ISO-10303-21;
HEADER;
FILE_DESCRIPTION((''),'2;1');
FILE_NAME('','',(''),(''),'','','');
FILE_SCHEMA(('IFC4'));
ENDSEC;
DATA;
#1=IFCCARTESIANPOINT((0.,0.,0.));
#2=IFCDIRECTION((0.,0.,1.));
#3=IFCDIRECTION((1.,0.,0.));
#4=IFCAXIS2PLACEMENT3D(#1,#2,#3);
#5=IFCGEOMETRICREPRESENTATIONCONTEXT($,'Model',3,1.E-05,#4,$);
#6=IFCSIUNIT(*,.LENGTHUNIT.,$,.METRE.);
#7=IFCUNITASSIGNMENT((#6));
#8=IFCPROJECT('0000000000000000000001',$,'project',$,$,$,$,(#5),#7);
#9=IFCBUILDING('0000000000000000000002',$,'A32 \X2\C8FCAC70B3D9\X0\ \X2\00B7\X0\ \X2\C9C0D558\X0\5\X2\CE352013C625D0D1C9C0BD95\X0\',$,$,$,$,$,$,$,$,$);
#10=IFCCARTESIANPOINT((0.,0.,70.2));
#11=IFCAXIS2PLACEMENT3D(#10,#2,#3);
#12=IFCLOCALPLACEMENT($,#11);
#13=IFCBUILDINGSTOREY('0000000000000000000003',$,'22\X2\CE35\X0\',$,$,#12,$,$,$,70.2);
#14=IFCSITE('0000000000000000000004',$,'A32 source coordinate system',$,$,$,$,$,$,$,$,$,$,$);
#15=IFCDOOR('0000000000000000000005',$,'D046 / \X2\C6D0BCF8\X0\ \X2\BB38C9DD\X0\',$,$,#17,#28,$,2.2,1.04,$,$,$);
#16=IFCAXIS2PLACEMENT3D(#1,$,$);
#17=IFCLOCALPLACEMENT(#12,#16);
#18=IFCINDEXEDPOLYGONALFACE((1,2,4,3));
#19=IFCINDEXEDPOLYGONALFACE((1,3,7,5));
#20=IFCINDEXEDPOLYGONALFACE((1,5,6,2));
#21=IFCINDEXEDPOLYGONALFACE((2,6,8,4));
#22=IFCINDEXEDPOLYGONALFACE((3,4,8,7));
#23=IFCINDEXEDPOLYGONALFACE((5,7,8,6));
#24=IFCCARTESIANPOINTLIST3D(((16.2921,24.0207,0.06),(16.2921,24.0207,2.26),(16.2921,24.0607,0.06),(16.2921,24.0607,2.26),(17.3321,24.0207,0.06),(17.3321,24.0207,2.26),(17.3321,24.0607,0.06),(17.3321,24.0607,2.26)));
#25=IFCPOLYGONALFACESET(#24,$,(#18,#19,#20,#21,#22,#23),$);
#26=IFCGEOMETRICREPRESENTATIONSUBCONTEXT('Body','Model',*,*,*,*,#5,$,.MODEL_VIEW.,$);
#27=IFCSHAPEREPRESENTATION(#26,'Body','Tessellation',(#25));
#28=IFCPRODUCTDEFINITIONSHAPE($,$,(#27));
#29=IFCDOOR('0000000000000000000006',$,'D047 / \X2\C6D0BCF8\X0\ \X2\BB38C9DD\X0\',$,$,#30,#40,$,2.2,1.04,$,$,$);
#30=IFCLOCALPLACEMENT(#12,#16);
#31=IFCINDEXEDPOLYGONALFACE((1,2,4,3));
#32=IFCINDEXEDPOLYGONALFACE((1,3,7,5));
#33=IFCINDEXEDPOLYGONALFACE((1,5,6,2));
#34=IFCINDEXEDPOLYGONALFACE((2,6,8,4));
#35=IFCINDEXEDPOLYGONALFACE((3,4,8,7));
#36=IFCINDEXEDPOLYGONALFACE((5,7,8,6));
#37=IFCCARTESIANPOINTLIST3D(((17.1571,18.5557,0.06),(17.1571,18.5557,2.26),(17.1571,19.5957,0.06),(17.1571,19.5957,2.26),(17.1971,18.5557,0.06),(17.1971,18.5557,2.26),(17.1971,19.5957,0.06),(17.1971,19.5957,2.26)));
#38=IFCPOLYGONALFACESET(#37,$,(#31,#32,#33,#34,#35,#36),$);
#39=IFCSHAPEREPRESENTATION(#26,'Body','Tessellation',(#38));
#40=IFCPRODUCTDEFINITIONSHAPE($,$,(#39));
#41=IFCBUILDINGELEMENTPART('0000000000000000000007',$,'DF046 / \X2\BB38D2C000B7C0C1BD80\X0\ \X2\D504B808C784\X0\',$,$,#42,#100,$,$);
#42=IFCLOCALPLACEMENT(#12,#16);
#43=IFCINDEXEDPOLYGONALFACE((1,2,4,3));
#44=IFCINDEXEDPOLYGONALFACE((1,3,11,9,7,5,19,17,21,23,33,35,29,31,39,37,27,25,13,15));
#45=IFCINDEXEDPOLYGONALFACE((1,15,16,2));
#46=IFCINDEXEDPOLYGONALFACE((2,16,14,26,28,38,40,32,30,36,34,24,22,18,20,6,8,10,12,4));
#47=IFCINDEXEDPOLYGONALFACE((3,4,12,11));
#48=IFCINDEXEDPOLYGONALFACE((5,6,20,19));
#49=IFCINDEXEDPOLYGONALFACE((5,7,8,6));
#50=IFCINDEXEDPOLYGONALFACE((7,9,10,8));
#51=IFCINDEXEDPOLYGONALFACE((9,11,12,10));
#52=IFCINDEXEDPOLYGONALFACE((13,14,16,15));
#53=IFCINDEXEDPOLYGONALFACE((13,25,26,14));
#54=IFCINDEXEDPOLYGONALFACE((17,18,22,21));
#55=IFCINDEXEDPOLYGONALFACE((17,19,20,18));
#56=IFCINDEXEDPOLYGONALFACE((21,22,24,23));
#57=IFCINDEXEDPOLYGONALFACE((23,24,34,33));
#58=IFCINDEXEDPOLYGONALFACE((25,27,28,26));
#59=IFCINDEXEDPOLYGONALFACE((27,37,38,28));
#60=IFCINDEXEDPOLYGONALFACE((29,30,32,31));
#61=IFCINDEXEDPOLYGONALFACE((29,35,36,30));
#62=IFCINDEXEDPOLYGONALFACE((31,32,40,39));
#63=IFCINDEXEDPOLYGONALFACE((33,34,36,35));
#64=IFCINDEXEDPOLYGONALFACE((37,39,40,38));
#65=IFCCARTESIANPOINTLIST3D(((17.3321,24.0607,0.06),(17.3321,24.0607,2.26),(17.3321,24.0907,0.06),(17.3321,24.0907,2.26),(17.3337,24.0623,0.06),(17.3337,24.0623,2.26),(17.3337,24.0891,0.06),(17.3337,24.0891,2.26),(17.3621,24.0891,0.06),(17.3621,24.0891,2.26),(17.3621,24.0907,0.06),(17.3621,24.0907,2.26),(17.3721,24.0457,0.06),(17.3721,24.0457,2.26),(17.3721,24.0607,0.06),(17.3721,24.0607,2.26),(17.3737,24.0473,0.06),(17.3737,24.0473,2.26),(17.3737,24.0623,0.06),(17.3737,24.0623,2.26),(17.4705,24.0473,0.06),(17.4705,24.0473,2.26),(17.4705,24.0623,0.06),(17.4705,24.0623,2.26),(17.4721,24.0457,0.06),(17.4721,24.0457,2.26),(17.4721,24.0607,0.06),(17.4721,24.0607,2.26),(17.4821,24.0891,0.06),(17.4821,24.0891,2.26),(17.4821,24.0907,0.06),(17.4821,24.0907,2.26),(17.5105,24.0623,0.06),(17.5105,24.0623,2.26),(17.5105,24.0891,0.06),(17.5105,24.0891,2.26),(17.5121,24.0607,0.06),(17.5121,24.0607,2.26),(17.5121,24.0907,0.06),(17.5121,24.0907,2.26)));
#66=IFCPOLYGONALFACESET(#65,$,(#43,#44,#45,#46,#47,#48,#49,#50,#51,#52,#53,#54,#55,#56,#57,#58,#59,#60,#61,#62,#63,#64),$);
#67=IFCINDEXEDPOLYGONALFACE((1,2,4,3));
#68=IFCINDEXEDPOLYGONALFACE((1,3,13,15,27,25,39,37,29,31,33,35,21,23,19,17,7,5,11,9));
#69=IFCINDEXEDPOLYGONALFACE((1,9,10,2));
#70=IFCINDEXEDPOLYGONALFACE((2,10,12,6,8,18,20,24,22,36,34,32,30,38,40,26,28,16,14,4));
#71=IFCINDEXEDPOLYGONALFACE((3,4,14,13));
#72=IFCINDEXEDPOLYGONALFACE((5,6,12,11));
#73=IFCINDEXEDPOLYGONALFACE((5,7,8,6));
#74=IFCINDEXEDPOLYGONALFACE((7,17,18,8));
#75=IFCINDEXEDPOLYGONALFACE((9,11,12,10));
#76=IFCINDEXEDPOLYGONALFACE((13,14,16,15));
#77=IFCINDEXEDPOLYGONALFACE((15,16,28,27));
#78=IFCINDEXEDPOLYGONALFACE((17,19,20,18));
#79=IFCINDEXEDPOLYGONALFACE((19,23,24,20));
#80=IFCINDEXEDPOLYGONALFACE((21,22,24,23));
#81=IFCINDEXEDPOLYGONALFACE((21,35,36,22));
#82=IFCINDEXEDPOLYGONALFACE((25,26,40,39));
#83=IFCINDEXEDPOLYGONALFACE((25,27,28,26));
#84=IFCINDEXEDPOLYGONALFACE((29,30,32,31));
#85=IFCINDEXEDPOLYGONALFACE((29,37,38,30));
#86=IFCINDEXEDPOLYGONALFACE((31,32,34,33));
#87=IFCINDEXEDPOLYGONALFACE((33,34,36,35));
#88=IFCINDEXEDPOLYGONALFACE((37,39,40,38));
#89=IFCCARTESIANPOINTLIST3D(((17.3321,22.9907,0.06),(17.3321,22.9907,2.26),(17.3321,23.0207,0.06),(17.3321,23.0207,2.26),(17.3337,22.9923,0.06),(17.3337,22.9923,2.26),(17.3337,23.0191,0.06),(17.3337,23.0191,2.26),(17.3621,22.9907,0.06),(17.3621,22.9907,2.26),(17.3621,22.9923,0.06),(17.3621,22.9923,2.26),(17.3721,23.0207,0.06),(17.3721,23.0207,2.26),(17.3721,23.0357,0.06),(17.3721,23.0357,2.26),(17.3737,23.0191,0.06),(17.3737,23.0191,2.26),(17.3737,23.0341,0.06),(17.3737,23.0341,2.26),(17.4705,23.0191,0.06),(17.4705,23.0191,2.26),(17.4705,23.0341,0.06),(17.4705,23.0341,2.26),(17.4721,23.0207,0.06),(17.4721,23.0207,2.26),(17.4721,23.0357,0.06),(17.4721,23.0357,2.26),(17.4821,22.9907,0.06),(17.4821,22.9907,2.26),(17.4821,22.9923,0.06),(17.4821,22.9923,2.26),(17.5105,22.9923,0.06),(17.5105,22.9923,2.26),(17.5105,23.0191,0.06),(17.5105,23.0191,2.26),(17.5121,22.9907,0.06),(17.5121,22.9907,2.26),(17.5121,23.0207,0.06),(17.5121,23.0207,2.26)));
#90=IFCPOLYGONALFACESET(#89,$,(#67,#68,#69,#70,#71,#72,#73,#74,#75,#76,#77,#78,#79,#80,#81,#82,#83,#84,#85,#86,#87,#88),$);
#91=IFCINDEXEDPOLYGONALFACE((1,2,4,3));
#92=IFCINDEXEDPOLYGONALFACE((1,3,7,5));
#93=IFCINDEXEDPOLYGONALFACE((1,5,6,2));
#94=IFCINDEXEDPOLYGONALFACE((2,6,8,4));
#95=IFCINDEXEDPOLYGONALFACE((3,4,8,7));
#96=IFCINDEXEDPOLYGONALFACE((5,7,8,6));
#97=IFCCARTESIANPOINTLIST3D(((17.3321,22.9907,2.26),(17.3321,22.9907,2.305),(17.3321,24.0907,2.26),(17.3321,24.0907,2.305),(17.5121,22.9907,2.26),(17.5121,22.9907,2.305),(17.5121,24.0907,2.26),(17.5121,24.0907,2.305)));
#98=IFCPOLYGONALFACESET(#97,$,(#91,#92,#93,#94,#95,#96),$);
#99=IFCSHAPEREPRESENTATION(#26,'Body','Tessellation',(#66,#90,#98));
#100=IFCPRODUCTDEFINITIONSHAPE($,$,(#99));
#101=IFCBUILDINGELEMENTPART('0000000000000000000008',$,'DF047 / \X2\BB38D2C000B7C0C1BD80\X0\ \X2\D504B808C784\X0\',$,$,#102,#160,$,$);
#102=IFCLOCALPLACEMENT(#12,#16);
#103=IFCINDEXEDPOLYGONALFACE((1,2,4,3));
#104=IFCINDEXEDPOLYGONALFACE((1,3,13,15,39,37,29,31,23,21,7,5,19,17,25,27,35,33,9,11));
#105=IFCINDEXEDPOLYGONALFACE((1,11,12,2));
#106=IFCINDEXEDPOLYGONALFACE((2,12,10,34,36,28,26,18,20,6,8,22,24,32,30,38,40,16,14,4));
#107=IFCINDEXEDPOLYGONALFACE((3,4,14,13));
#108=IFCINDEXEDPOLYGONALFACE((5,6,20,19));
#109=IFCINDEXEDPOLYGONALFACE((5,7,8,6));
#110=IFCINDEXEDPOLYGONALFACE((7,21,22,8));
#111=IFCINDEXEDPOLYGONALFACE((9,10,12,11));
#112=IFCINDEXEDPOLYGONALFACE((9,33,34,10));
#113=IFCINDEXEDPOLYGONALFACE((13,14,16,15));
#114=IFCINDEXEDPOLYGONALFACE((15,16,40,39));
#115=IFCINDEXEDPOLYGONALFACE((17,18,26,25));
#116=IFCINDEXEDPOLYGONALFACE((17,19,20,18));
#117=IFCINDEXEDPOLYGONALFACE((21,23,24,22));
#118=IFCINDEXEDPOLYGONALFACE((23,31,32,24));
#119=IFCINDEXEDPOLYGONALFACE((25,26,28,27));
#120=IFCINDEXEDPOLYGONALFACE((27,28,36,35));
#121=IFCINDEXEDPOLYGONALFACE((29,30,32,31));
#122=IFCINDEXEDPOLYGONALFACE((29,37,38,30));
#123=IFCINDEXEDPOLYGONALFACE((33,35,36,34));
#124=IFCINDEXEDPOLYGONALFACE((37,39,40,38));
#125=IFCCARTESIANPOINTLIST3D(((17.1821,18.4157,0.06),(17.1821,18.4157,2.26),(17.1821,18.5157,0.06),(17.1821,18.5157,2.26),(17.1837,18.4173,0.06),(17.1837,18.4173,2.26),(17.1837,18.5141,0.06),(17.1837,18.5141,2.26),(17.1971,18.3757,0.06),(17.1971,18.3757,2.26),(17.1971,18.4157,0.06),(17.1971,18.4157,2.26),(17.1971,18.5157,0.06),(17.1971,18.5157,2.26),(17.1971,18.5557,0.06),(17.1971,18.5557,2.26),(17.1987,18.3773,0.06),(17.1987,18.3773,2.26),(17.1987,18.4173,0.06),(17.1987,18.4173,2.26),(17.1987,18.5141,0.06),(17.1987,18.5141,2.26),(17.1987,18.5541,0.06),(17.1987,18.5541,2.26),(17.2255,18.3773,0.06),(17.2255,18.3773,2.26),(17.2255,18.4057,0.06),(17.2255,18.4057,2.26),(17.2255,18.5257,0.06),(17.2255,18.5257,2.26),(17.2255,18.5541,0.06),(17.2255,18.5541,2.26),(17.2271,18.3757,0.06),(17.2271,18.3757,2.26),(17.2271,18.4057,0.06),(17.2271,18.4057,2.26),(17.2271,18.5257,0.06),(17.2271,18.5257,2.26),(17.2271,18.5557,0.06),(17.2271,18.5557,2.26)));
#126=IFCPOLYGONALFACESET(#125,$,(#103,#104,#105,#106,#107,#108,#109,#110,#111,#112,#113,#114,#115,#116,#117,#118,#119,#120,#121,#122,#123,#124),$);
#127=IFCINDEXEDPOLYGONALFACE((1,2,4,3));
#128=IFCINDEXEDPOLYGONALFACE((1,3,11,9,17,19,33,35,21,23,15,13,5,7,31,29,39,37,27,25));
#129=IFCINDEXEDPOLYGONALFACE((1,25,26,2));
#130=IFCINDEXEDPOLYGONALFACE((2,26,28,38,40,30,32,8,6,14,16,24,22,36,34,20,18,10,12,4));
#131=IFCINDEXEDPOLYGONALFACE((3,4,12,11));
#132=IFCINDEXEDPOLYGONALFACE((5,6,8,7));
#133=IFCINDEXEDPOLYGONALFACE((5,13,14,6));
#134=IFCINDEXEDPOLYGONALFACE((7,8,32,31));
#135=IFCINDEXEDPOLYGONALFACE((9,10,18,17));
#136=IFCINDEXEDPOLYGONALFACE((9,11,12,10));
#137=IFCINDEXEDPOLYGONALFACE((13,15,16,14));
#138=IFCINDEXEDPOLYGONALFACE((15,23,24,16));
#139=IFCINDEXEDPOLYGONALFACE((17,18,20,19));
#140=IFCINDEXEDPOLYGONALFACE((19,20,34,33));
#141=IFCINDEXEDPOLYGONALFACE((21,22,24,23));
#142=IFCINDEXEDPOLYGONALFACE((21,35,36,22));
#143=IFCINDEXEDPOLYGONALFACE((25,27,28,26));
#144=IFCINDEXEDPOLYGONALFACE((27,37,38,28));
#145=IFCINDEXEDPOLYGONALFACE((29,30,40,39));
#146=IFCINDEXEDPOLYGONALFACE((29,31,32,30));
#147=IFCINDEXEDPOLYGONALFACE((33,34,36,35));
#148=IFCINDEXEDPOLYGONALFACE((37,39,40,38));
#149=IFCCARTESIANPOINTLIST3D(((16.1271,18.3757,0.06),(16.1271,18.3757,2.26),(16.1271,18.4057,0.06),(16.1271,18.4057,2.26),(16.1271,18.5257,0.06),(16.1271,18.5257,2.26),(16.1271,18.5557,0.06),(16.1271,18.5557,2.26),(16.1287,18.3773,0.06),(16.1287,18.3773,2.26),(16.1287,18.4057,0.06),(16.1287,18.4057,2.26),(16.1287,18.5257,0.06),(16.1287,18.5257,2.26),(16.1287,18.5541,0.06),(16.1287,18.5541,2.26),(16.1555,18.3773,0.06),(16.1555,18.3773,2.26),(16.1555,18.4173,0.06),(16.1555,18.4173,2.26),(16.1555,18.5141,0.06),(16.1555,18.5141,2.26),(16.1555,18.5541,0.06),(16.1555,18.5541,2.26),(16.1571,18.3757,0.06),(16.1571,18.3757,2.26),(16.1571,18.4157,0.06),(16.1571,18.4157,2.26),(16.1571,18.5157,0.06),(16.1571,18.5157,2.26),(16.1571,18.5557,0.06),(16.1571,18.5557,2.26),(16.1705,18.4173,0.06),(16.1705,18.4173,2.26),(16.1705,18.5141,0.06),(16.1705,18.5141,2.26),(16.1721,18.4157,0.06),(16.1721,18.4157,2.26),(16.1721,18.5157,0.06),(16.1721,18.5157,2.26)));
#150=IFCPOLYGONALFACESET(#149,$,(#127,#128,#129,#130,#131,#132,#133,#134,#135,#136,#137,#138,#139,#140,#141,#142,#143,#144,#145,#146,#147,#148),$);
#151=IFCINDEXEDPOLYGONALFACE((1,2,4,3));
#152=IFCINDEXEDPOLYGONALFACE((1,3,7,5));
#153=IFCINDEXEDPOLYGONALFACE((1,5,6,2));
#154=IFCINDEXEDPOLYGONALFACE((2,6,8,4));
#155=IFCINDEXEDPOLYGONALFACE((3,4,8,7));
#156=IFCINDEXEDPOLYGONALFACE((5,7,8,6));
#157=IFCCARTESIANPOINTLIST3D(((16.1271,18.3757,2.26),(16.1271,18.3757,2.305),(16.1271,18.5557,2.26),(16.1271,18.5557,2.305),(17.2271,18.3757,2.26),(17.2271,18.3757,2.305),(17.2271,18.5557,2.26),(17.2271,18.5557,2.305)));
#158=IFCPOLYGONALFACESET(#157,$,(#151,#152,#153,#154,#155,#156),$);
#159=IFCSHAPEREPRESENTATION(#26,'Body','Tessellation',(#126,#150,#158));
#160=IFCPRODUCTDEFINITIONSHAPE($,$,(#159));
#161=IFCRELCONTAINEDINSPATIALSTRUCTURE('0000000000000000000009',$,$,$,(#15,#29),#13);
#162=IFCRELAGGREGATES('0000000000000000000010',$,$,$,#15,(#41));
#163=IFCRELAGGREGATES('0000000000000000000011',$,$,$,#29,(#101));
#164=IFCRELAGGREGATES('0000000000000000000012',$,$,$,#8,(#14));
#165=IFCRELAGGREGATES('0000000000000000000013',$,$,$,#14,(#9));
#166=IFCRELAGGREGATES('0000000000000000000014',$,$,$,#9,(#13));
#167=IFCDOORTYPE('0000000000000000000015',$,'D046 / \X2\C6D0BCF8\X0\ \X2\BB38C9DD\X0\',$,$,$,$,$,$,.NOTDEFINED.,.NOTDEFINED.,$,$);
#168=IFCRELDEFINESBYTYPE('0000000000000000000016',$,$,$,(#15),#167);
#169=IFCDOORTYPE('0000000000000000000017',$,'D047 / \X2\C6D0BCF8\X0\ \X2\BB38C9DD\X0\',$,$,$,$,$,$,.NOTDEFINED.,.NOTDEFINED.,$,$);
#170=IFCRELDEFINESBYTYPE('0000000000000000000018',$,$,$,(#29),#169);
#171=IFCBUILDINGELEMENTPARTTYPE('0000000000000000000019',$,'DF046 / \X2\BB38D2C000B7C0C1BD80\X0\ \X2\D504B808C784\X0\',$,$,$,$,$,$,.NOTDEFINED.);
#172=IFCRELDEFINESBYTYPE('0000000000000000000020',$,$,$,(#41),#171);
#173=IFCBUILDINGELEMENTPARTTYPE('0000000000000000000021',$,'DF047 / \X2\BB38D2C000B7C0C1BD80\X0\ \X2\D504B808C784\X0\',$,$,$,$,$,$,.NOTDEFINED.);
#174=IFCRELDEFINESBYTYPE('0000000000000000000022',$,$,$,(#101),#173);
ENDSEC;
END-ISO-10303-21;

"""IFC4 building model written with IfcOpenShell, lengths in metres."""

from ifc_helpers import new_model, si_unit, frame, origin, origin_with_axes, place, context, subcontext, project, spatial, polyline, outline, extrude, source, transform, mapped, type_object, type_shapes, element, aggregate, save


model = new_model("IFC4")

# Units and contexts
model_context = context("Model", 3, precision=1e-05, world=origin_with_axes())
body_context = subcontext(model_context, "Body", "Model", "MODEL_VIEW")
ifc_project = project(units=[si_unit("LENGTHUNIT", "METRE")], contexts=[model_context])

# Site, building, storey
storey_placement = place(None, frame((0.0, 0.0, 70.2), z_axis=(0.0, 0.0, 1.0), x_axis=(1.0, 0.0, 0.0)))
site = spatial("IfcSite", under=ifc_project, Name="A32 source coordinate system")
building = spatial("IfcBuilding", under=site, Name="A32 주거동 · 지하5층–옥탑지붕")
storey = spatial("IfcBuildingStorey", under=building, at=storey_placement, Name="22층", Elevation=70.2)

# Doors
door_type_1 = type_object("IfcDoorType", Name="D046 / 원본 문짝", OperationType="NOTDEFINED", PredefinedType="NOTDEFINED")
shared_shape_1 = source(origin(), body_context, "Body", "SweptSolid", [
    extrude(outline(polyline([(17.3321, 24.0607), (17.3321, 24.0207), (16.2921, 24.0207), (16.2921, 24.0607), (17.3321, 24.0607)])), frame((0.0, 0.0, 0.06)), (0.0, 0.0, 1.0), 2.2),
])
type_shapes(door_type_1, [shared_shape_1])
door_1_placement = place(storey_placement, origin_with_axes())
door_1 = element("IfcDoor", 1, at=door_1_placement, inside=storey, type_object=door_type_1, Name="D046 / 원본 문짝", OverallHeight=2.2, OverallWidth=1.04, context=body_context, shape_type="MappedRepresentation", body=[
    mapped(shared_shape_1, transform((0.0, 0.0, 0.0), scale=1.0)),
])
door_type_2 = type_object("IfcDoorType", Name="D047 / 원본 문짝", OperationType="NOTDEFINED", PredefinedType="NOTDEFINED")
shared_shape_2 = source(origin(), body_context, "Body", "SweptSolid", [
    extrude(outline(polyline([(17.1971, 18.5557), (17.1571, 18.5557), (17.1571, 19.5957), (17.1971, 19.5957), (17.1971, 18.5557)])), frame((0.0, 0.0, 0.06)), (0.0, 0.0, 1.0), 2.2),
])
type_shapes(door_type_2, [shared_shape_2])
door_2_placement = place(storey_placement, origin_with_axes())
door_2 = element("IfcDoor", 2, at=door_2_placement, inside=storey, type_object=door_type_2, Name="D047 / 원본 문짝", OverallHeight=2.2, OverallWidth=1.04, context=body_context, shape_type="MappedRepresentation", body=[
    mapped(shared_shape_2, transform((0.0, 0.0, 0.0), scale=1.0)),
])

# Building element parts
building_element_part_type_1 = type_object("IfcBuildingElementPartType", Name="DF046 / 문틀·상부 프레임", PredefinedType="NOTDEFINED")
shared_shape_3 = source(origin(), body_context, "Body", "SweptSolid", [
    extrude(outline(polyline([(17.3337, 24.0891), (17.3337, 24.0623), (17.3737, 24.0623), (17.3737, 24.0473), (17.4705, 24.0473), (17.4705, 24.0623), (17.5105, 24.0623), (17.5105, 24.0891), (17.4821, 24.0891), (17.4821, 24.0907), (17.5121, 24.0907), (17.5121, 24.0607), (17.4721, 24.0607), (17.4721, 24.0457), (17.3721, 24.0457), (17.3721, 24.0607), (17.3321, 24.0607), (17.3321, 24.0907), (17.3621, 24.0907), (17.3621, 24.0891), (17.3337, 24.0891)])), frame((0.0, 0.0, 0.06)), (0.0, 0.0, 1.0), 2.2),
    extrude(outline(polyline([(17.3621, 22.9907), (17.3321, 22.9907), (17.3321, 23.0207), (17.3721, 23.0207), (17.3721, 23.0357), (17.4721, 23.0357), (17.4721, 23.0207), (17.5121, 23.0207), (17.5121, 22.9907), (17.4821, 22.9907), (17.4821, 22.9923), (17.5105, 22.9923), (17.5105, 23.0191), (17.4705, 23.0191), (17.4705, 23.0341), (17.3737, 23.0341), (17.3737, 23.0191), (17.3337, 23.0191), (17.3337, 22.9923), (17.3621, 22.9923), (17.3621, 22.9907)])), frame((0.0, 0.0, 0.06)), (0.0, 0.0, 1.0), 2.2),
    extrude(outline(polyline([(17.3321, 22.9907), (17.3321, 24.0907), (17.5121, 24.0907), (17.5121, 22.9907), (17.3321, 22.9907)])), frame((0.0, 0.0, 2.26)), (0.0, 0.0, 1.0), 0.045),
])
type_shapes(building_element_part_type_1, [shared_shape_3])
building_element_part_1_placement = place(door_1_placement, origin_with_axes())
building_element_part_1 = element("IfcBuildingElementPart", 3, at=building_element_part_1_placement, type_object=building_element_part_type_1, Name="DF046 / 문틀·상부 프레임", context=body_context, shape_type="MappedRepresentation", body=[
    mapped(shared_shape_3, transform((0.0, 0.0, 0.0), scale=1.0)),
])
aggregate(door_1, [building_element_part_1])
building_element_part_type_2 = type_object("IfcBuildingElementPartType", Name="DF047 / 문틀·상부 프레임", PredefinedType="NOTDEFINED")
shared_shape_4 = source(origin(), body_context, "Body", "SweptSolid", [
    extrude(outline(polyline([(17.2255, 18.5541), (17.1987, 18.5541), (17.1987, 18.5141), (17.1837, 18.5141), (17.1837, 18.4173), (17.1987, 18.4173), (17.1987, 18.3773), (17.2255, 18.3773), (17.2255, 18.4057), (17.2271, 18.4057), (17.2271, 18.3757), (17.1971, 18.3757), (17.1971, 18.4157), (17.1821, 18.4157), (17.1821, 18.5157), (17.1971, 18.5157), (17.1971, 18.5557), (17.2271, 18.5557), (17.2271, 18.5257), (17.2255, 18.5257), (17.2255, 18.5541)])), frame((0.0, 0.0, 0.06)), (0.0, 0.0, 1.0), 2.2),
    extrude(outline(polyline([(16.1271, 18.5257), (16.1271, 18.5557), (16.1571, 18.5557), (16.1571, 18.5157), (16.1721, 18.5157), (16.1721, 18.4157), (16.1571, 18.4157), (16.1571, 18.3757), (16.1271, 18.3757), (16.1271, 18.4057), (16.1287, 18.4057), (16.1287, 18.3773), (16.1555, 18.3773), (16.1555, 18.4173), (16.1705, 18.4173), (16.1705, 18.5141), (16.1555, 18.5141), (16.1555, 18.5541), (16.1287, 18.5541), (16.1287, 18.5257), (16.1271, 18.5257)])), frame((0.0, 0.0, 0.06)), (0.0, 0.0, 1.0), 2.2),
    extrude(outline(polyline([(16.1271, 18.3757), (16.1271, 18.5557), (17.2271, 18.5557), (17.2271, 18.3757), (16.1271, 18.3757)])), frame((0.0, 0.0, 2.26)), (0.0, 0.0, 1.0), 0.045),
])
type_shapes(building_element_part_type_2, [shared_shape_4])
building_element_part_2_placement = place(door_2_placement, origin_with_axes())
building_element_part_2 = element("IfcBuildingElementPart", 4, at=building_element_part_2_placement, type_object=building_element_part_type_2, Name="DF047 / 문틀·상부 프레임", context=body_context, shape_type="MappedRepresentation", body=[
    mapped(shared_shape_4, transform((0.0, 0.0, 0.0), scale=1.0)),
])
aggregate(door_2, [building_element_part_2])

save(model, "model.ifc")
